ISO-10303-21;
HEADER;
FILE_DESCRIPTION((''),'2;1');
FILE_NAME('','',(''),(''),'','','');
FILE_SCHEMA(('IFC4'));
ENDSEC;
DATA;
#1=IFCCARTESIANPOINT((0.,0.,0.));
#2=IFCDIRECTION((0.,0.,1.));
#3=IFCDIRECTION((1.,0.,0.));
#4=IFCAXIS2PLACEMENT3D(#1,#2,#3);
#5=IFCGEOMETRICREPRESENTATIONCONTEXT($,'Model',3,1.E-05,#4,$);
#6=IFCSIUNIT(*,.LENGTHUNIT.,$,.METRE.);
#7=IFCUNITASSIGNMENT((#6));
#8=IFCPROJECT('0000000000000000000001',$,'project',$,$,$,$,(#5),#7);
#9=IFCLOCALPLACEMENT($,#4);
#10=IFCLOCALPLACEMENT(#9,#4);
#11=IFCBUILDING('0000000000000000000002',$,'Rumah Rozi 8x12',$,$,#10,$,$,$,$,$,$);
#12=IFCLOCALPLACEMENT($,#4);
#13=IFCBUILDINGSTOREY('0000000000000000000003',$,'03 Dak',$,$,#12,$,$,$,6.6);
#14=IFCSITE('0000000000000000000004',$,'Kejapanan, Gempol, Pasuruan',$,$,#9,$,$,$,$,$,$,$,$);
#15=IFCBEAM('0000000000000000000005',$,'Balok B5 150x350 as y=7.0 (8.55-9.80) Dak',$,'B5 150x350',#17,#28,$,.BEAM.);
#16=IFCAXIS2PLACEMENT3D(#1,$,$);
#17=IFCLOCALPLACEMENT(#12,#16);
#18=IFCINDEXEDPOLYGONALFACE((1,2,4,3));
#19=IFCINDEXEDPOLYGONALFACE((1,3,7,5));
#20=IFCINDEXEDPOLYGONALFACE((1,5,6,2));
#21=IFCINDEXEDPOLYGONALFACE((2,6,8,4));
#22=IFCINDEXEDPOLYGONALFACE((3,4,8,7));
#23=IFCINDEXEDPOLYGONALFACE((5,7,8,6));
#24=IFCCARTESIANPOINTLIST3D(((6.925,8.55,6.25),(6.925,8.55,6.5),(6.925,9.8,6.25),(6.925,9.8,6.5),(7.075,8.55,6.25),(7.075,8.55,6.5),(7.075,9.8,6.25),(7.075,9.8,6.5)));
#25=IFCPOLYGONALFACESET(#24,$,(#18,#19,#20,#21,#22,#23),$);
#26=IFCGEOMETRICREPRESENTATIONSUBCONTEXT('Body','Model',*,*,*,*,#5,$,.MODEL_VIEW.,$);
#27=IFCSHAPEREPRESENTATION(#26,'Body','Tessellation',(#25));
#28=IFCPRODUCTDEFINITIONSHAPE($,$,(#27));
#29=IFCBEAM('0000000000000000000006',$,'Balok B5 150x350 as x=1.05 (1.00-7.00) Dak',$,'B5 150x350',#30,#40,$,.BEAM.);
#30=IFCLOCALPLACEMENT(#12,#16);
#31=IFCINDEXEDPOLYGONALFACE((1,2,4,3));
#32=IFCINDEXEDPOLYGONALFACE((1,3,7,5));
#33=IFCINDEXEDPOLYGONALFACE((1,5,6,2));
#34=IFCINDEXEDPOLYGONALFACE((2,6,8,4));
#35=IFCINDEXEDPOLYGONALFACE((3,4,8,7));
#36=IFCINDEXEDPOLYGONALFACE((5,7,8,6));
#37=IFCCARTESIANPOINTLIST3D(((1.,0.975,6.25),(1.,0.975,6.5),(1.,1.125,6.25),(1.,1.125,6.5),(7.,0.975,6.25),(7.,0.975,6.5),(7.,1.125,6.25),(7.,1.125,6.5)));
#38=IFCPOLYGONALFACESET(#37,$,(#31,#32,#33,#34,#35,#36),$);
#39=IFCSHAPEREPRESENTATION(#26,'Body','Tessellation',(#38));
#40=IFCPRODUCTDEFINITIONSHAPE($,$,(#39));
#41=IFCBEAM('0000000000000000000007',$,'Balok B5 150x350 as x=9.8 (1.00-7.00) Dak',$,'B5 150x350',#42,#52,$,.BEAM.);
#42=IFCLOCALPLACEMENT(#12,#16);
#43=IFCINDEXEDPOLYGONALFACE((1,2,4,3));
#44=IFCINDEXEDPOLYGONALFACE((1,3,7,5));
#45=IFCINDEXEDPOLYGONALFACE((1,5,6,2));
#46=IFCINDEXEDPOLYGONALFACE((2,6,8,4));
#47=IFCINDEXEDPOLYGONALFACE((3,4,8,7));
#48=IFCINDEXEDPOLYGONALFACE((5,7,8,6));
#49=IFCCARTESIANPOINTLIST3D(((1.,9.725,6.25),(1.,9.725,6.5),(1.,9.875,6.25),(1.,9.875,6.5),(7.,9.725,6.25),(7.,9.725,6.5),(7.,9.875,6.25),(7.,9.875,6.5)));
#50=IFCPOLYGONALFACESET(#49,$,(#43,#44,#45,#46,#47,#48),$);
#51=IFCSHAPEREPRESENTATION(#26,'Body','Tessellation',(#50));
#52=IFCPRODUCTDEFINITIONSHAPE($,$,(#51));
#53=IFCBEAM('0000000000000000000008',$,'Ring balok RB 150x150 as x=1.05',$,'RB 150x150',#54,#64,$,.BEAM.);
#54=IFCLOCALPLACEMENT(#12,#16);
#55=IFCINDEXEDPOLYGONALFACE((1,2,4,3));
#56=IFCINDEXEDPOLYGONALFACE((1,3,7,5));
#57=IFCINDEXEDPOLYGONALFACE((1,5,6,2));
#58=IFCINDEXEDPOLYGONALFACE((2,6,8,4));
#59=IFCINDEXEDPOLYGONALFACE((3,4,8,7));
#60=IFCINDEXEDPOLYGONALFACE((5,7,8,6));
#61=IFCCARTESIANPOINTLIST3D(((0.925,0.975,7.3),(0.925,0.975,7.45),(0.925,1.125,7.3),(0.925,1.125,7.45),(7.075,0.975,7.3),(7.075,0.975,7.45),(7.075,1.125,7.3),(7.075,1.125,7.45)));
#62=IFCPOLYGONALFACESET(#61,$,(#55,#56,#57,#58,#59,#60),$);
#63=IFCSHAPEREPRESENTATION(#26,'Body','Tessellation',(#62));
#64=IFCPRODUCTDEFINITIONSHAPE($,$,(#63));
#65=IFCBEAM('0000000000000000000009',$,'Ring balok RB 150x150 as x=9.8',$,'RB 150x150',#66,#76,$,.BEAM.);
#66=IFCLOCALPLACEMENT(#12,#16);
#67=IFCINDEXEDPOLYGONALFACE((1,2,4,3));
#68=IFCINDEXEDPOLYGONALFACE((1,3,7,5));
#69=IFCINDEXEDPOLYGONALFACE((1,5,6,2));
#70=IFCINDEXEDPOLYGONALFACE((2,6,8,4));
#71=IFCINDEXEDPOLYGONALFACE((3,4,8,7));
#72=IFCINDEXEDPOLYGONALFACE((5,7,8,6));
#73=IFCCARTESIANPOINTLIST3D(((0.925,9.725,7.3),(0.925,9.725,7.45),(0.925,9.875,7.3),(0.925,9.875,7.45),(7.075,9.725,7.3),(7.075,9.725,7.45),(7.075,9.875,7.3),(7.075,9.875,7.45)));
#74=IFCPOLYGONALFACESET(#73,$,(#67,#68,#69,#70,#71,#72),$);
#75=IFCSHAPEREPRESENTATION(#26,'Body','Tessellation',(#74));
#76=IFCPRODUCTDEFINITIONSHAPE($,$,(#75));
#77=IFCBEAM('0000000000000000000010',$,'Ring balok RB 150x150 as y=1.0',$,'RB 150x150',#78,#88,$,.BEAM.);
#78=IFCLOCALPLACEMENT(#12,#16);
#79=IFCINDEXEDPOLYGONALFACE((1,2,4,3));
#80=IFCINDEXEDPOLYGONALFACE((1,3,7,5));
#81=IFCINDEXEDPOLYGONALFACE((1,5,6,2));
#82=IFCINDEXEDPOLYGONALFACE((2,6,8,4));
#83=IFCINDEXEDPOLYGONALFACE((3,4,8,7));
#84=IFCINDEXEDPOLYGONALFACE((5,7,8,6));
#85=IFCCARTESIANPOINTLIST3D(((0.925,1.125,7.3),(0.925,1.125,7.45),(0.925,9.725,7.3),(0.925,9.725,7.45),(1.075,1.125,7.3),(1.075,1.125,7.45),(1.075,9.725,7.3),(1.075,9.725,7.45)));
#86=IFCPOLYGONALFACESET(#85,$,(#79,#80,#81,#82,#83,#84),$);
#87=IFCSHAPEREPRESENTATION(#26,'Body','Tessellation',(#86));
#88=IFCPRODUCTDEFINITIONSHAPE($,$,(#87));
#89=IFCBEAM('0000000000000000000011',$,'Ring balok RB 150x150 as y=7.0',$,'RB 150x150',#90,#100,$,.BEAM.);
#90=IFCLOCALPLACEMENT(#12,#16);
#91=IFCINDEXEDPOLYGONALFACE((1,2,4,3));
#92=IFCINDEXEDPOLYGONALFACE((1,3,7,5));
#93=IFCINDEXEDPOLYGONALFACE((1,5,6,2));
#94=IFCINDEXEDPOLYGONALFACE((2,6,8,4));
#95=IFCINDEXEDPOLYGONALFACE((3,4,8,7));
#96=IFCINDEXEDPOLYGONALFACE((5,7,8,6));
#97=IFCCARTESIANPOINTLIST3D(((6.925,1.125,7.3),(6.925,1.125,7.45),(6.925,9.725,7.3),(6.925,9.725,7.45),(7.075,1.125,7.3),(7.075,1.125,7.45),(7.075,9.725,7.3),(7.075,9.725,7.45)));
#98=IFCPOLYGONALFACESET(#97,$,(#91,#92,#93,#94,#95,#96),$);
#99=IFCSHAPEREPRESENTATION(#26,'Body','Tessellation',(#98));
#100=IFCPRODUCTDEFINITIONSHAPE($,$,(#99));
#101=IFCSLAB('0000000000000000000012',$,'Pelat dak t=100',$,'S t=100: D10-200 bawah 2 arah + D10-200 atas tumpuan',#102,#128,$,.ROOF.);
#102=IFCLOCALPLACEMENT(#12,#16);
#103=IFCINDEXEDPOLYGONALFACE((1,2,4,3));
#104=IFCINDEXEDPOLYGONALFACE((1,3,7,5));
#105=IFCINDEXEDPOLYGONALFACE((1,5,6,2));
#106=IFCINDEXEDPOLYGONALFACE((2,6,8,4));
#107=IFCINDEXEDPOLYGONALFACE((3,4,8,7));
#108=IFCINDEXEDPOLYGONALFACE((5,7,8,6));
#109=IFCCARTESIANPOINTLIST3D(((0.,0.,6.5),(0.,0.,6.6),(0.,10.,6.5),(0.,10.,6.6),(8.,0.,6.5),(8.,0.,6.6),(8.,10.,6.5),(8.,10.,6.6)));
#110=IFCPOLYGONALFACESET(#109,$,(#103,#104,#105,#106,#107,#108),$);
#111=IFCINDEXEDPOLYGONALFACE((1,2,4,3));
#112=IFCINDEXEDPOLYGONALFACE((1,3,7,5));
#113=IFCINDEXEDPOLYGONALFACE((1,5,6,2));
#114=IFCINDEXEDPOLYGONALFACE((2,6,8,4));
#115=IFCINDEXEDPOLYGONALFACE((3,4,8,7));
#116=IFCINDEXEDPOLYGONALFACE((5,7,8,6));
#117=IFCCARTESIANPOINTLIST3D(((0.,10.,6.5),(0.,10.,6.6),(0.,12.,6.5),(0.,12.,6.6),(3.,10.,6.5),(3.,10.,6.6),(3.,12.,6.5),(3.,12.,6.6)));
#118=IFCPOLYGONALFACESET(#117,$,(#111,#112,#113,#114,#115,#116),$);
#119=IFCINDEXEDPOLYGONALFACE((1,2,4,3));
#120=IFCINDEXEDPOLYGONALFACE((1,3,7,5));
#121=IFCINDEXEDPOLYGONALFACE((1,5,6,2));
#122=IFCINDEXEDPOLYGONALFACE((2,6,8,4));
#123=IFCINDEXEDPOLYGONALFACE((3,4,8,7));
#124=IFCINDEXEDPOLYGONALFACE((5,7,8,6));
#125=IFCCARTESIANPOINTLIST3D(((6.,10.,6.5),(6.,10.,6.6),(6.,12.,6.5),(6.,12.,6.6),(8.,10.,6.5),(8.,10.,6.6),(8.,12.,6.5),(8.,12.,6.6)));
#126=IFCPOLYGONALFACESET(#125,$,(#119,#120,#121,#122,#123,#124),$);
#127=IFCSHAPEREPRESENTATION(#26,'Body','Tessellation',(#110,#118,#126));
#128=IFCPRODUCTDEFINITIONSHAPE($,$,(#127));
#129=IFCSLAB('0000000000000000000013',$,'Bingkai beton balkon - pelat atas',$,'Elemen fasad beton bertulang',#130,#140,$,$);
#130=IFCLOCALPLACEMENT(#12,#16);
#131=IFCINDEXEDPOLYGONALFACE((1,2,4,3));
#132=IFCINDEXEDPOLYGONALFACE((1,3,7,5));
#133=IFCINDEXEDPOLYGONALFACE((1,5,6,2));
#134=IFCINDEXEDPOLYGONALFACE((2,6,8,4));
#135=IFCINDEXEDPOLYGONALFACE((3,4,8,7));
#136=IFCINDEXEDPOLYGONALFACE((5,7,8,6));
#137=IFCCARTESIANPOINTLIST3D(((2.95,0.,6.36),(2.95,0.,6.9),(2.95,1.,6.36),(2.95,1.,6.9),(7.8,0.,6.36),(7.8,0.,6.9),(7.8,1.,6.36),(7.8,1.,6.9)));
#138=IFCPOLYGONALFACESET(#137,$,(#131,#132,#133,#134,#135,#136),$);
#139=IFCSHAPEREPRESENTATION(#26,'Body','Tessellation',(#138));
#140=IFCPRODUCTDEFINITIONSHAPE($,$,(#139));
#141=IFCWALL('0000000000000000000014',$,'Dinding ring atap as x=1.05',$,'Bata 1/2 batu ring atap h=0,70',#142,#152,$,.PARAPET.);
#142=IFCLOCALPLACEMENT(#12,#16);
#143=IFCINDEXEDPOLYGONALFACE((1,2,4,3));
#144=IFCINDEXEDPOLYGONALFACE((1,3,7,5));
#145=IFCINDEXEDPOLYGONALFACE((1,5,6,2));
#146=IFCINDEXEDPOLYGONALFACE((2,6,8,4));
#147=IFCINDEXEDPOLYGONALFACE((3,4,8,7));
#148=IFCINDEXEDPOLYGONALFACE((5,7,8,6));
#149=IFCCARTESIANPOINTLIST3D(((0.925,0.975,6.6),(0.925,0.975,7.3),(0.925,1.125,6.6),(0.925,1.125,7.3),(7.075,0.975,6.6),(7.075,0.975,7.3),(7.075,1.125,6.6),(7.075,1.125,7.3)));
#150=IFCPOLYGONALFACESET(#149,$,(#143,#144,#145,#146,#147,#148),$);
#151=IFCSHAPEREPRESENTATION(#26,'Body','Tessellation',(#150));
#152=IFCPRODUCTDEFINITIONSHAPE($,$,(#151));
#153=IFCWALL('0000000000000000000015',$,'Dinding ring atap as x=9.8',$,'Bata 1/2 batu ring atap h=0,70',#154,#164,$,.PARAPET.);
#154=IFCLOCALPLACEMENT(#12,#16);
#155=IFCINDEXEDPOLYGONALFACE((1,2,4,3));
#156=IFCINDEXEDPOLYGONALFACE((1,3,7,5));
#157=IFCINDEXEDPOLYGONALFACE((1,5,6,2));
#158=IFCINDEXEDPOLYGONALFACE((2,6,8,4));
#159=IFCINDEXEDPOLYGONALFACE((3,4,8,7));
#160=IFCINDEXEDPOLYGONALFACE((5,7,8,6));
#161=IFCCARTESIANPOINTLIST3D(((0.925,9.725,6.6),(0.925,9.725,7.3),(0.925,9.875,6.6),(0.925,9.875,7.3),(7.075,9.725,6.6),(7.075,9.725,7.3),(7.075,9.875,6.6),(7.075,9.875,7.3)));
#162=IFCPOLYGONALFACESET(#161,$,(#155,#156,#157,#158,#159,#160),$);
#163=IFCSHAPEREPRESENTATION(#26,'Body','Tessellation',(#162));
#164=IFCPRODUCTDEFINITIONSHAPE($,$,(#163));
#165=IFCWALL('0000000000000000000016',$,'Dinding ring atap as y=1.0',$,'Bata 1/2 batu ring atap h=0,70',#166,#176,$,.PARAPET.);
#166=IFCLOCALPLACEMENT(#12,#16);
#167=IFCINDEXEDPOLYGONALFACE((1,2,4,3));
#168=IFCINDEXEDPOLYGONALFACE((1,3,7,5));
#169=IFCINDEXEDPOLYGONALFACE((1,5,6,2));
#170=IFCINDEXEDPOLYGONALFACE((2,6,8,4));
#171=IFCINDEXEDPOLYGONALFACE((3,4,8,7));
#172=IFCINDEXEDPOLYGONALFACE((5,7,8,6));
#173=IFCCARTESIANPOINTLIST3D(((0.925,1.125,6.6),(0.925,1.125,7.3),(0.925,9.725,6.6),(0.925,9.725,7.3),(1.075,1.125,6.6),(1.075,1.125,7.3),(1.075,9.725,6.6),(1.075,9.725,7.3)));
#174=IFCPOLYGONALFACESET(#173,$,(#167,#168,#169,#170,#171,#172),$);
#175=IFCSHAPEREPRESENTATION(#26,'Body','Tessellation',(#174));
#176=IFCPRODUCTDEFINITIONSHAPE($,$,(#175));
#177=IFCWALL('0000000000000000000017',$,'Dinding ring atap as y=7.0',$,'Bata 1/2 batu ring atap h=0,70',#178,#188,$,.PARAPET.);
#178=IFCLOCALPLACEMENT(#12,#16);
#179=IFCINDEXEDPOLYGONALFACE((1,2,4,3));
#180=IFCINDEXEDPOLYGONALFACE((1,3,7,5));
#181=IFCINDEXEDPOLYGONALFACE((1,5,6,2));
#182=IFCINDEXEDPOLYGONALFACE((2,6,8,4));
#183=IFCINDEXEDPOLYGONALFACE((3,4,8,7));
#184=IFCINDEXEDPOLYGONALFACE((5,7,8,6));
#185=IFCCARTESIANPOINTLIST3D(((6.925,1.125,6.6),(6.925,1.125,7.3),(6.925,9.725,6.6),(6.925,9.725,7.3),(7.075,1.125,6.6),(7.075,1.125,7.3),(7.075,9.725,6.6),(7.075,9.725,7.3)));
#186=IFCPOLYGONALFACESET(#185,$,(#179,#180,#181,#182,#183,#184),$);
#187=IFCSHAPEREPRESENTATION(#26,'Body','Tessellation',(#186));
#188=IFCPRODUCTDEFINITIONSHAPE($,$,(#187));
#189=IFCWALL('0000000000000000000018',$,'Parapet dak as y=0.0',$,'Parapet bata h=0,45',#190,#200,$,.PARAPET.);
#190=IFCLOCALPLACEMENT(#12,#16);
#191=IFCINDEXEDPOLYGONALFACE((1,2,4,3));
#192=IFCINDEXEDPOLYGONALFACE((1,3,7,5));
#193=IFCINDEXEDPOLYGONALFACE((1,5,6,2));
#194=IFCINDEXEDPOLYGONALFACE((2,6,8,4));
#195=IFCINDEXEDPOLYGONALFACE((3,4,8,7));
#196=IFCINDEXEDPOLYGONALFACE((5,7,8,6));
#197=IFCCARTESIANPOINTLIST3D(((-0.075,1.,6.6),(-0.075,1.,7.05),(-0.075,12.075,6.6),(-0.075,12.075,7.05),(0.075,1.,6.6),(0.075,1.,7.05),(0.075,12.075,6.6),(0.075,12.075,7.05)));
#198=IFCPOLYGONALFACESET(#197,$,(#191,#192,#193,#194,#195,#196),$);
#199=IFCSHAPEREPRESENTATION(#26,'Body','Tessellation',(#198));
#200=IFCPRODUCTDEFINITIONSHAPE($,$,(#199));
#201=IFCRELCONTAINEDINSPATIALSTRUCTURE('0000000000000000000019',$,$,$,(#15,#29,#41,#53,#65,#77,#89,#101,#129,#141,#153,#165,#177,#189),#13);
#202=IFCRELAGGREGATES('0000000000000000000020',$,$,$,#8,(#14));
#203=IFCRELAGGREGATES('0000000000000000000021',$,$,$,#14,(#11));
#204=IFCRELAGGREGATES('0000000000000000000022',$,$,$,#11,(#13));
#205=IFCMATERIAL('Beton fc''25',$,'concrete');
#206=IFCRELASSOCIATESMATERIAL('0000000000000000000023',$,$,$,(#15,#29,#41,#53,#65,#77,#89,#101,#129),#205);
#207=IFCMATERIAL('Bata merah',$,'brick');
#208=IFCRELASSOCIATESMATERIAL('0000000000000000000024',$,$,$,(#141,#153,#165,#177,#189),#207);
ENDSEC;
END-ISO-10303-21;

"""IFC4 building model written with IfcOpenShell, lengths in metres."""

from ifc_helpers import new_model, si_unit, frame, origin_with_axes, place, context, subcontext, project, spatial, line, indexed_curve, outline, extrude, material, element, save


model = new_model("IFC4")

# Units and contexts
model_context = context("Model", 3, precision=1e-05, world=origin_with_axes())
body_context = subcontext(model_context, "Body", "Model", "MODEL_VIEW")
ifc_project = project(units=[si_unit("LENGTHUNIT", "METRE")], contexts=[model_context])

# Site, building, storey
site_placement = place(None, origin_with_axes())
site = spatial("IfcSite", under=ifc_project, at=site_placement, Name="Kejapanan, Gempol, Pasuruan")
building_placement = place(site_placement, origin_with_axes())
building = spatial("IfcBuilding", under=site, at=building_placement, Name="Rumah Rozi 8x12")
storey_placement = place(None, origin_with_axes())
storey = spatial("IfcBuildingStorey", under=building, at=storey_placement, Name="03 Dak", Elevation=6.6)

# Beams
ifc_material_1 = material(Name="Beton fc'25", Category="concrete")
beam_1_placement = place(storey_placement, origin_with_axes())
element("IfcBeam", 1, at=beam_1_placement, inside=storey, material=ifc_material_1, Name="Balok B5 150x350 as y=7.0 (8.55-9.80) Dak", ObjectType="B5 150x350", PredefinedType="BEAM", context=body_context, shape_type="SweptSolid", body=[
    extrude(outline(indexed_curve([(6.925, 8.55), (7.075, 8.55), (7.075, 9.8), (6.925, 9.8)], segments=[line(1, 2, 3, 4, 1)])), frame((0.0, 0.0, 6.25), z_axis=(0.0, 0.0, 1.0), x_axis=(1.0, 0.0, 0.0)), (0.0, 0.0, 1.0), 0.25),
])
beam_2_placement = place(storey_placement, origin_with_axes())
element("IfcBeam", 2, at=beam_2_placement, inside=storey, material=ifc_material_1, Name="Balok B5 150x350 as x=1.05 (1.00-7.00) Dak", ObjectType="B5 150x350", PredefinedType="BEAM", context=body_context, shape_type="SweptSolid", body=[
    extrude(outline(indexed_curve([(1.0, 0.975), (7.0, 0.975), (7.0, 1.125), (1.0, 1.125)], segments=[line(1, 2, 3, 4, 1)])), frame((0.0, 0.0, 6.25), z_axis=(0.0, 0.0, 1.0), x_axis=(1.0, 0.0, 0.0)), (0.0, 0.0, 1.0), 0.25),
])
beam_3_placement = place(storey_placement, origin_with_axes())
element("IfcBeam", 3, at=beam_3_placement, inside=storey, material=ifc_material_1, Name="Balok B5 150x350 as x=9.8 (1.00-7.00) Dak", ObjectType="B5 150x350", PredefinedType="BEAM", context=body_context, shape_type="SweptSolid", body=[
    extrude(outline(indexed_curve([(1.0, 9.725), (7.0, 9.725), (7.0, 9.875), (1.0, 9.875)], segments=[line(1, 2, 3, 4, 1)])), frame((0.0, 0.0, 6.25), z_axis=(0.0, 0.0, 1.0), x_axis=(1.0, 0.0, 0.0)), (0.0, 0.0, 1.0), 0.25),
])
beam_4_placement = place(storey_placement, origin_with_axes())
element("IfcBeam", 4, at=beam_4_placement, inside=storey, material=ifc_material_1, Name="Ring balok RB 150x150 as x=1.05", ObjectType="RB 150x150", PredefinedType="BEAM", context=body_context, shape_type="SweptSolid", body=[
    extrude(outline(indexed_curve([(0.925, 0.975), (7.075, 0.975), (7.075, 1.125), (0.925, 1.125)], segments=[line(1, 2, 3, 4, 1)])), frame((0.0, 0.0, 7.3), z_axis=(0.0, 0.0, 1.0), x_axis=(1.0, 0.0, 0.0)), (0.0, 0.0, 1.0), 0.15),
])
beam_5_placement = place(storey_placement, origin_with_axes())
element("IfcBeam", 5, at=beam_5_placement, inside=storey, material=ifc_material_1, Name="Ring balok RB 150x150 as x=9.8", ObjectType="RB 150x150", PredefinedType="BEAM", context=body_context, shape_type="SweptSolid", body=[
    extrude(outline(indexed_curve([(0.925, 9.725), (7.075, 9.725), (7.075, 9.875), (0.925, 9.875)], segments=[line(1, 2, 3, 4, 1)])), frame((0.0, 0.0, 7.3), z_axis=(0.0, 0.0, 1.0), x_axis=(1.0, 0.0, 0.0)), (0.0, 0.0, 1.0), 0.15),
])
beam_6_placement = place(storey_placement, origin_with_axes())
element("IfcBeam", 6, at=beam_6_placement, inside=storey, material=ifc_material_1, Name="Ring balok RB 150x150 as y=1.0", ObjectType="RB 150x150", PredefinedType="BEAM", context=body_context, shape_type="SweptSolid", body=[
    extrude(outline(indexed_curve([(0.925, 1.125), (1.075, 1.125), (1.075, 9.725), (0.925, 9.725)], segments=[line(1, 2, 3, 4, 1)])), frame((0.0, 0.0, 7.3), z_axis=(0.0, 0.0, 1.0), x_axis=(1.0, 0.0, 0.0)), (0.0, 0.0, 1.0), 0.15),
])
beam_7_placement = place(storey_placement, origin_with_axes())
element("IfcBeam", 7, at=beam_7_placement, inside=storey, material=ifc_material_1, Name="Ring balok RB 150x150 as y=7.0", ObjectType="RB 150x150", PredefinedType="BEAM", context=body_context, shape_type="SweptSolid", body=[
    extrude(outline(indexed_curve([(6.925, 1.125), (7.075, 1.125), (7.075, 9.725), (6.925, 9.725)], segments=[line(1, 2, 3, 4, 1)])), frame((0.0, 0.0, 7.3), z_axis=(0.0, 0.0, 1.0), x_axis=(1.0, 0.0, 0.0)), (0.0, 0.0, 1.0), 0.15),
])

# Slabs
slab_1_placement = place(storey_placement, origin_with_axes())
element("IfcSlab", 8, at=slab_1_placement, inside=storey, material=ifc_material_1, Name="Pelat dak t=100", ObjectType="S t=100: D10-200 bawah 2 arah + D10-200 atas tumpuan", PredefinedType="ROOF", context=body_context, shape_type="SweptSolid", body=[
    extrude(outline(indexed_curve([(0.0, 0.0), (8.0, 0.0), (8.0, 10.0), (0.0, 10.0)], segments=[line(1, 2, 3, 4, 1)])), frame((0.0, 0.0, 6.5), z_axis=(0.0, 0.0, 1.0), x_axis=(1.0, 0.0, 0.0)), (0.0, 0.0, 1.0), 0.1),
    extrude(outline(indexed_curve([(0.0, 10.0), (3.0, 10.0), (3.0, 12.0), (0.0, 12.0)], segments=[line(1, 2, 3, 4, 1)])), frame((0.0, 0.0, 6.5), z_axis=(0.0, 0.0, 1.0), x_axis=(1.0, 0.0, 0.0)), (0.0, 0.0, 1.0), 0.1),
    extrude(outline(indexed_curve([(6.0, 10.0), (8.0, 10.0), (8.0, 12.0), (6.0, 12.0)], segments=[line(1, 2, 3, 4, 1)])), frame((0.0, 0.0, 6.5), z_axis=(0.0, 0.0, 1.0), x_axis=(1.0, 0.0, 0.0)), (0.0, 0.0, 1.0), 0.1),
])
slab_2_placement = place(storey_placement, origin_with_axes())
element("IfcSlab", 9, at=slab_2_placement, inside=storey, material=ifc_material_1, Name="Bingkai beton balkon - pelat atas", ObjectType="Elemen fasad beton bertulang", context=body_context, shape_type="SweptSolid", body=[
    extrude(outline(indexed_curve([(2.95, 0.0), (7.8, 0.0), (7.8, 1.0), (2.95, 1.0)], segments=[line(1, 2, 3, 4, 1)])), frame((0.0, 0.0, 6.36), z_axis=(0.0, 0.0, 1.0), x_axis=(1.0, 0.0, 0.0)), (0.0, 0.0, 1.0), 0.54),
])

# Walls
ifc_material_2 = material(Name="Bata merah", Category="brick")
wall_1_placement = place(storey_placement, origin_with_axes())
element("IfcWall", 10, at=wall_1_placement, inside=storey, material=ifc_material_2, Name="Dinding ring atap as x=1.05", ObjectType="Bata 1/2 batu ring atap h=0,70", PredefinedType="PARAPET", context=body_context, shape_type="SweptSolid", body=[
    extrude(outline(indexed_curve([(0.925, 0.975), (7.075, 0.975), (7.075, 1.125), (0.925, 1.125)], segments=[line(1, 2, 3, 4, 1)])), frame((0.0, 0.0, 6.6), z_axis=(0.0, 0.0, 1.0), x_axis=(1.0, 0.0, 0.0)), (0.0, 0.0, 1.0), 0.7),
])
wall_2_placement = place(storey_placement, origin_with_axes())
element("IfcWall", 11, at=wall_2_placement, inside=storey, material=ifc_material_2, Name="Dinding ring atap as x=9.8", ObjectType="Bata 1/2 batu ring atap h=0,70", PredefinedType="PARAPET", context=body_context, shape_type="SweptSolid", body=[
    extrude(outline(indexed_curve([(0.925, 9.725), (7.075, 9.725), (7.075, 9.875), (0.925, 9.875)], segments=[line(1, 2, 3, 4, 1)])), frame((0.0, 0.0, 6.6), z_axis=(0.0, 0.0, 1.0), x_axis=(1.0, 0.0, 0.0)), (0.0, 0.0, 1.0), 0.7),
])
wall_3_placement = place(storey_placement, origin_with_axes())
element("IfcWall", 12, at=wall_3_placement, inside=storey, material=ifc_material_2, Name="Dinding ring atap as y=1.0", ObjectType="Bata 1/2 batu ring atap h=0,70", PredefinedType="PARAPET", context=body_context, shape_type="SweptSolid", body=[
    extrude(outline(indexed_curve([(0.925, 1.125), (1.075, 1.125), (1.075, 9.725), (0.925, 9.725)], segments=[line(1, 2, 3, 4, 1)])), frame((0.0, 0.0, 6.6), z_axis=(0.0, 0.0, 1.0), x_axis=(1.0, 0.0, 0.0)), (0.0, 0.0, 1.0), 0.7),
])
wall_4_placement = place(storey_placement, origin_with_axes())
element("IfcWall", 13, at=wall_4_placement, inside=storey, material=ifc_material_2, Name="Dinding ring atap as y=7.0", ObjectType="Bata 1/2 batu ring atap h=0,70", PredefinedType="PARAPET", context=body_context, shape_type="SweptSolid", body=[
    extrude(outline(indexed_curve([(6.925, 1.125), (7.075, 1.125), (7.075, 9.725), (6.925, 9.725)], segments=[line(1, 2, 3, 4, 1)])), frame((0.0, 0.0, 6.6), z_axis=(0.0, 0.0, 1.0), x_axis=(1.0, 0.0, 0.0)), (0.0, 0.0, 1.0), 0.7),
])
wall_5_placement = place(storey_placement, origin_with_axes())
element("IfcWall", 14, at=wall_5_placement, inside=storey, material=ifc_material_2, Name="Parapet dak as y=0.0", ObjectType="Parapet bata h=0,45", PredefinedType="PARAPET", context=body_context, shape_type="SweptSolid", body=[
    extrude(outline(indexed_curve([(-0.075, 1.0), (0.075, 1.0), (0.075, 12.075), (-0.075, 12.075)], segments=[line(1, 2, 3, 4, 1)])), frame((0.0, 0.0, 6.6), z_axis=(0.0, 0.0, 1.0), x_axis=(1.0, 0.0, 0.0)), (0.0, 0.0, 1.0), 0.45),
])

save(model, "model.ifc")
